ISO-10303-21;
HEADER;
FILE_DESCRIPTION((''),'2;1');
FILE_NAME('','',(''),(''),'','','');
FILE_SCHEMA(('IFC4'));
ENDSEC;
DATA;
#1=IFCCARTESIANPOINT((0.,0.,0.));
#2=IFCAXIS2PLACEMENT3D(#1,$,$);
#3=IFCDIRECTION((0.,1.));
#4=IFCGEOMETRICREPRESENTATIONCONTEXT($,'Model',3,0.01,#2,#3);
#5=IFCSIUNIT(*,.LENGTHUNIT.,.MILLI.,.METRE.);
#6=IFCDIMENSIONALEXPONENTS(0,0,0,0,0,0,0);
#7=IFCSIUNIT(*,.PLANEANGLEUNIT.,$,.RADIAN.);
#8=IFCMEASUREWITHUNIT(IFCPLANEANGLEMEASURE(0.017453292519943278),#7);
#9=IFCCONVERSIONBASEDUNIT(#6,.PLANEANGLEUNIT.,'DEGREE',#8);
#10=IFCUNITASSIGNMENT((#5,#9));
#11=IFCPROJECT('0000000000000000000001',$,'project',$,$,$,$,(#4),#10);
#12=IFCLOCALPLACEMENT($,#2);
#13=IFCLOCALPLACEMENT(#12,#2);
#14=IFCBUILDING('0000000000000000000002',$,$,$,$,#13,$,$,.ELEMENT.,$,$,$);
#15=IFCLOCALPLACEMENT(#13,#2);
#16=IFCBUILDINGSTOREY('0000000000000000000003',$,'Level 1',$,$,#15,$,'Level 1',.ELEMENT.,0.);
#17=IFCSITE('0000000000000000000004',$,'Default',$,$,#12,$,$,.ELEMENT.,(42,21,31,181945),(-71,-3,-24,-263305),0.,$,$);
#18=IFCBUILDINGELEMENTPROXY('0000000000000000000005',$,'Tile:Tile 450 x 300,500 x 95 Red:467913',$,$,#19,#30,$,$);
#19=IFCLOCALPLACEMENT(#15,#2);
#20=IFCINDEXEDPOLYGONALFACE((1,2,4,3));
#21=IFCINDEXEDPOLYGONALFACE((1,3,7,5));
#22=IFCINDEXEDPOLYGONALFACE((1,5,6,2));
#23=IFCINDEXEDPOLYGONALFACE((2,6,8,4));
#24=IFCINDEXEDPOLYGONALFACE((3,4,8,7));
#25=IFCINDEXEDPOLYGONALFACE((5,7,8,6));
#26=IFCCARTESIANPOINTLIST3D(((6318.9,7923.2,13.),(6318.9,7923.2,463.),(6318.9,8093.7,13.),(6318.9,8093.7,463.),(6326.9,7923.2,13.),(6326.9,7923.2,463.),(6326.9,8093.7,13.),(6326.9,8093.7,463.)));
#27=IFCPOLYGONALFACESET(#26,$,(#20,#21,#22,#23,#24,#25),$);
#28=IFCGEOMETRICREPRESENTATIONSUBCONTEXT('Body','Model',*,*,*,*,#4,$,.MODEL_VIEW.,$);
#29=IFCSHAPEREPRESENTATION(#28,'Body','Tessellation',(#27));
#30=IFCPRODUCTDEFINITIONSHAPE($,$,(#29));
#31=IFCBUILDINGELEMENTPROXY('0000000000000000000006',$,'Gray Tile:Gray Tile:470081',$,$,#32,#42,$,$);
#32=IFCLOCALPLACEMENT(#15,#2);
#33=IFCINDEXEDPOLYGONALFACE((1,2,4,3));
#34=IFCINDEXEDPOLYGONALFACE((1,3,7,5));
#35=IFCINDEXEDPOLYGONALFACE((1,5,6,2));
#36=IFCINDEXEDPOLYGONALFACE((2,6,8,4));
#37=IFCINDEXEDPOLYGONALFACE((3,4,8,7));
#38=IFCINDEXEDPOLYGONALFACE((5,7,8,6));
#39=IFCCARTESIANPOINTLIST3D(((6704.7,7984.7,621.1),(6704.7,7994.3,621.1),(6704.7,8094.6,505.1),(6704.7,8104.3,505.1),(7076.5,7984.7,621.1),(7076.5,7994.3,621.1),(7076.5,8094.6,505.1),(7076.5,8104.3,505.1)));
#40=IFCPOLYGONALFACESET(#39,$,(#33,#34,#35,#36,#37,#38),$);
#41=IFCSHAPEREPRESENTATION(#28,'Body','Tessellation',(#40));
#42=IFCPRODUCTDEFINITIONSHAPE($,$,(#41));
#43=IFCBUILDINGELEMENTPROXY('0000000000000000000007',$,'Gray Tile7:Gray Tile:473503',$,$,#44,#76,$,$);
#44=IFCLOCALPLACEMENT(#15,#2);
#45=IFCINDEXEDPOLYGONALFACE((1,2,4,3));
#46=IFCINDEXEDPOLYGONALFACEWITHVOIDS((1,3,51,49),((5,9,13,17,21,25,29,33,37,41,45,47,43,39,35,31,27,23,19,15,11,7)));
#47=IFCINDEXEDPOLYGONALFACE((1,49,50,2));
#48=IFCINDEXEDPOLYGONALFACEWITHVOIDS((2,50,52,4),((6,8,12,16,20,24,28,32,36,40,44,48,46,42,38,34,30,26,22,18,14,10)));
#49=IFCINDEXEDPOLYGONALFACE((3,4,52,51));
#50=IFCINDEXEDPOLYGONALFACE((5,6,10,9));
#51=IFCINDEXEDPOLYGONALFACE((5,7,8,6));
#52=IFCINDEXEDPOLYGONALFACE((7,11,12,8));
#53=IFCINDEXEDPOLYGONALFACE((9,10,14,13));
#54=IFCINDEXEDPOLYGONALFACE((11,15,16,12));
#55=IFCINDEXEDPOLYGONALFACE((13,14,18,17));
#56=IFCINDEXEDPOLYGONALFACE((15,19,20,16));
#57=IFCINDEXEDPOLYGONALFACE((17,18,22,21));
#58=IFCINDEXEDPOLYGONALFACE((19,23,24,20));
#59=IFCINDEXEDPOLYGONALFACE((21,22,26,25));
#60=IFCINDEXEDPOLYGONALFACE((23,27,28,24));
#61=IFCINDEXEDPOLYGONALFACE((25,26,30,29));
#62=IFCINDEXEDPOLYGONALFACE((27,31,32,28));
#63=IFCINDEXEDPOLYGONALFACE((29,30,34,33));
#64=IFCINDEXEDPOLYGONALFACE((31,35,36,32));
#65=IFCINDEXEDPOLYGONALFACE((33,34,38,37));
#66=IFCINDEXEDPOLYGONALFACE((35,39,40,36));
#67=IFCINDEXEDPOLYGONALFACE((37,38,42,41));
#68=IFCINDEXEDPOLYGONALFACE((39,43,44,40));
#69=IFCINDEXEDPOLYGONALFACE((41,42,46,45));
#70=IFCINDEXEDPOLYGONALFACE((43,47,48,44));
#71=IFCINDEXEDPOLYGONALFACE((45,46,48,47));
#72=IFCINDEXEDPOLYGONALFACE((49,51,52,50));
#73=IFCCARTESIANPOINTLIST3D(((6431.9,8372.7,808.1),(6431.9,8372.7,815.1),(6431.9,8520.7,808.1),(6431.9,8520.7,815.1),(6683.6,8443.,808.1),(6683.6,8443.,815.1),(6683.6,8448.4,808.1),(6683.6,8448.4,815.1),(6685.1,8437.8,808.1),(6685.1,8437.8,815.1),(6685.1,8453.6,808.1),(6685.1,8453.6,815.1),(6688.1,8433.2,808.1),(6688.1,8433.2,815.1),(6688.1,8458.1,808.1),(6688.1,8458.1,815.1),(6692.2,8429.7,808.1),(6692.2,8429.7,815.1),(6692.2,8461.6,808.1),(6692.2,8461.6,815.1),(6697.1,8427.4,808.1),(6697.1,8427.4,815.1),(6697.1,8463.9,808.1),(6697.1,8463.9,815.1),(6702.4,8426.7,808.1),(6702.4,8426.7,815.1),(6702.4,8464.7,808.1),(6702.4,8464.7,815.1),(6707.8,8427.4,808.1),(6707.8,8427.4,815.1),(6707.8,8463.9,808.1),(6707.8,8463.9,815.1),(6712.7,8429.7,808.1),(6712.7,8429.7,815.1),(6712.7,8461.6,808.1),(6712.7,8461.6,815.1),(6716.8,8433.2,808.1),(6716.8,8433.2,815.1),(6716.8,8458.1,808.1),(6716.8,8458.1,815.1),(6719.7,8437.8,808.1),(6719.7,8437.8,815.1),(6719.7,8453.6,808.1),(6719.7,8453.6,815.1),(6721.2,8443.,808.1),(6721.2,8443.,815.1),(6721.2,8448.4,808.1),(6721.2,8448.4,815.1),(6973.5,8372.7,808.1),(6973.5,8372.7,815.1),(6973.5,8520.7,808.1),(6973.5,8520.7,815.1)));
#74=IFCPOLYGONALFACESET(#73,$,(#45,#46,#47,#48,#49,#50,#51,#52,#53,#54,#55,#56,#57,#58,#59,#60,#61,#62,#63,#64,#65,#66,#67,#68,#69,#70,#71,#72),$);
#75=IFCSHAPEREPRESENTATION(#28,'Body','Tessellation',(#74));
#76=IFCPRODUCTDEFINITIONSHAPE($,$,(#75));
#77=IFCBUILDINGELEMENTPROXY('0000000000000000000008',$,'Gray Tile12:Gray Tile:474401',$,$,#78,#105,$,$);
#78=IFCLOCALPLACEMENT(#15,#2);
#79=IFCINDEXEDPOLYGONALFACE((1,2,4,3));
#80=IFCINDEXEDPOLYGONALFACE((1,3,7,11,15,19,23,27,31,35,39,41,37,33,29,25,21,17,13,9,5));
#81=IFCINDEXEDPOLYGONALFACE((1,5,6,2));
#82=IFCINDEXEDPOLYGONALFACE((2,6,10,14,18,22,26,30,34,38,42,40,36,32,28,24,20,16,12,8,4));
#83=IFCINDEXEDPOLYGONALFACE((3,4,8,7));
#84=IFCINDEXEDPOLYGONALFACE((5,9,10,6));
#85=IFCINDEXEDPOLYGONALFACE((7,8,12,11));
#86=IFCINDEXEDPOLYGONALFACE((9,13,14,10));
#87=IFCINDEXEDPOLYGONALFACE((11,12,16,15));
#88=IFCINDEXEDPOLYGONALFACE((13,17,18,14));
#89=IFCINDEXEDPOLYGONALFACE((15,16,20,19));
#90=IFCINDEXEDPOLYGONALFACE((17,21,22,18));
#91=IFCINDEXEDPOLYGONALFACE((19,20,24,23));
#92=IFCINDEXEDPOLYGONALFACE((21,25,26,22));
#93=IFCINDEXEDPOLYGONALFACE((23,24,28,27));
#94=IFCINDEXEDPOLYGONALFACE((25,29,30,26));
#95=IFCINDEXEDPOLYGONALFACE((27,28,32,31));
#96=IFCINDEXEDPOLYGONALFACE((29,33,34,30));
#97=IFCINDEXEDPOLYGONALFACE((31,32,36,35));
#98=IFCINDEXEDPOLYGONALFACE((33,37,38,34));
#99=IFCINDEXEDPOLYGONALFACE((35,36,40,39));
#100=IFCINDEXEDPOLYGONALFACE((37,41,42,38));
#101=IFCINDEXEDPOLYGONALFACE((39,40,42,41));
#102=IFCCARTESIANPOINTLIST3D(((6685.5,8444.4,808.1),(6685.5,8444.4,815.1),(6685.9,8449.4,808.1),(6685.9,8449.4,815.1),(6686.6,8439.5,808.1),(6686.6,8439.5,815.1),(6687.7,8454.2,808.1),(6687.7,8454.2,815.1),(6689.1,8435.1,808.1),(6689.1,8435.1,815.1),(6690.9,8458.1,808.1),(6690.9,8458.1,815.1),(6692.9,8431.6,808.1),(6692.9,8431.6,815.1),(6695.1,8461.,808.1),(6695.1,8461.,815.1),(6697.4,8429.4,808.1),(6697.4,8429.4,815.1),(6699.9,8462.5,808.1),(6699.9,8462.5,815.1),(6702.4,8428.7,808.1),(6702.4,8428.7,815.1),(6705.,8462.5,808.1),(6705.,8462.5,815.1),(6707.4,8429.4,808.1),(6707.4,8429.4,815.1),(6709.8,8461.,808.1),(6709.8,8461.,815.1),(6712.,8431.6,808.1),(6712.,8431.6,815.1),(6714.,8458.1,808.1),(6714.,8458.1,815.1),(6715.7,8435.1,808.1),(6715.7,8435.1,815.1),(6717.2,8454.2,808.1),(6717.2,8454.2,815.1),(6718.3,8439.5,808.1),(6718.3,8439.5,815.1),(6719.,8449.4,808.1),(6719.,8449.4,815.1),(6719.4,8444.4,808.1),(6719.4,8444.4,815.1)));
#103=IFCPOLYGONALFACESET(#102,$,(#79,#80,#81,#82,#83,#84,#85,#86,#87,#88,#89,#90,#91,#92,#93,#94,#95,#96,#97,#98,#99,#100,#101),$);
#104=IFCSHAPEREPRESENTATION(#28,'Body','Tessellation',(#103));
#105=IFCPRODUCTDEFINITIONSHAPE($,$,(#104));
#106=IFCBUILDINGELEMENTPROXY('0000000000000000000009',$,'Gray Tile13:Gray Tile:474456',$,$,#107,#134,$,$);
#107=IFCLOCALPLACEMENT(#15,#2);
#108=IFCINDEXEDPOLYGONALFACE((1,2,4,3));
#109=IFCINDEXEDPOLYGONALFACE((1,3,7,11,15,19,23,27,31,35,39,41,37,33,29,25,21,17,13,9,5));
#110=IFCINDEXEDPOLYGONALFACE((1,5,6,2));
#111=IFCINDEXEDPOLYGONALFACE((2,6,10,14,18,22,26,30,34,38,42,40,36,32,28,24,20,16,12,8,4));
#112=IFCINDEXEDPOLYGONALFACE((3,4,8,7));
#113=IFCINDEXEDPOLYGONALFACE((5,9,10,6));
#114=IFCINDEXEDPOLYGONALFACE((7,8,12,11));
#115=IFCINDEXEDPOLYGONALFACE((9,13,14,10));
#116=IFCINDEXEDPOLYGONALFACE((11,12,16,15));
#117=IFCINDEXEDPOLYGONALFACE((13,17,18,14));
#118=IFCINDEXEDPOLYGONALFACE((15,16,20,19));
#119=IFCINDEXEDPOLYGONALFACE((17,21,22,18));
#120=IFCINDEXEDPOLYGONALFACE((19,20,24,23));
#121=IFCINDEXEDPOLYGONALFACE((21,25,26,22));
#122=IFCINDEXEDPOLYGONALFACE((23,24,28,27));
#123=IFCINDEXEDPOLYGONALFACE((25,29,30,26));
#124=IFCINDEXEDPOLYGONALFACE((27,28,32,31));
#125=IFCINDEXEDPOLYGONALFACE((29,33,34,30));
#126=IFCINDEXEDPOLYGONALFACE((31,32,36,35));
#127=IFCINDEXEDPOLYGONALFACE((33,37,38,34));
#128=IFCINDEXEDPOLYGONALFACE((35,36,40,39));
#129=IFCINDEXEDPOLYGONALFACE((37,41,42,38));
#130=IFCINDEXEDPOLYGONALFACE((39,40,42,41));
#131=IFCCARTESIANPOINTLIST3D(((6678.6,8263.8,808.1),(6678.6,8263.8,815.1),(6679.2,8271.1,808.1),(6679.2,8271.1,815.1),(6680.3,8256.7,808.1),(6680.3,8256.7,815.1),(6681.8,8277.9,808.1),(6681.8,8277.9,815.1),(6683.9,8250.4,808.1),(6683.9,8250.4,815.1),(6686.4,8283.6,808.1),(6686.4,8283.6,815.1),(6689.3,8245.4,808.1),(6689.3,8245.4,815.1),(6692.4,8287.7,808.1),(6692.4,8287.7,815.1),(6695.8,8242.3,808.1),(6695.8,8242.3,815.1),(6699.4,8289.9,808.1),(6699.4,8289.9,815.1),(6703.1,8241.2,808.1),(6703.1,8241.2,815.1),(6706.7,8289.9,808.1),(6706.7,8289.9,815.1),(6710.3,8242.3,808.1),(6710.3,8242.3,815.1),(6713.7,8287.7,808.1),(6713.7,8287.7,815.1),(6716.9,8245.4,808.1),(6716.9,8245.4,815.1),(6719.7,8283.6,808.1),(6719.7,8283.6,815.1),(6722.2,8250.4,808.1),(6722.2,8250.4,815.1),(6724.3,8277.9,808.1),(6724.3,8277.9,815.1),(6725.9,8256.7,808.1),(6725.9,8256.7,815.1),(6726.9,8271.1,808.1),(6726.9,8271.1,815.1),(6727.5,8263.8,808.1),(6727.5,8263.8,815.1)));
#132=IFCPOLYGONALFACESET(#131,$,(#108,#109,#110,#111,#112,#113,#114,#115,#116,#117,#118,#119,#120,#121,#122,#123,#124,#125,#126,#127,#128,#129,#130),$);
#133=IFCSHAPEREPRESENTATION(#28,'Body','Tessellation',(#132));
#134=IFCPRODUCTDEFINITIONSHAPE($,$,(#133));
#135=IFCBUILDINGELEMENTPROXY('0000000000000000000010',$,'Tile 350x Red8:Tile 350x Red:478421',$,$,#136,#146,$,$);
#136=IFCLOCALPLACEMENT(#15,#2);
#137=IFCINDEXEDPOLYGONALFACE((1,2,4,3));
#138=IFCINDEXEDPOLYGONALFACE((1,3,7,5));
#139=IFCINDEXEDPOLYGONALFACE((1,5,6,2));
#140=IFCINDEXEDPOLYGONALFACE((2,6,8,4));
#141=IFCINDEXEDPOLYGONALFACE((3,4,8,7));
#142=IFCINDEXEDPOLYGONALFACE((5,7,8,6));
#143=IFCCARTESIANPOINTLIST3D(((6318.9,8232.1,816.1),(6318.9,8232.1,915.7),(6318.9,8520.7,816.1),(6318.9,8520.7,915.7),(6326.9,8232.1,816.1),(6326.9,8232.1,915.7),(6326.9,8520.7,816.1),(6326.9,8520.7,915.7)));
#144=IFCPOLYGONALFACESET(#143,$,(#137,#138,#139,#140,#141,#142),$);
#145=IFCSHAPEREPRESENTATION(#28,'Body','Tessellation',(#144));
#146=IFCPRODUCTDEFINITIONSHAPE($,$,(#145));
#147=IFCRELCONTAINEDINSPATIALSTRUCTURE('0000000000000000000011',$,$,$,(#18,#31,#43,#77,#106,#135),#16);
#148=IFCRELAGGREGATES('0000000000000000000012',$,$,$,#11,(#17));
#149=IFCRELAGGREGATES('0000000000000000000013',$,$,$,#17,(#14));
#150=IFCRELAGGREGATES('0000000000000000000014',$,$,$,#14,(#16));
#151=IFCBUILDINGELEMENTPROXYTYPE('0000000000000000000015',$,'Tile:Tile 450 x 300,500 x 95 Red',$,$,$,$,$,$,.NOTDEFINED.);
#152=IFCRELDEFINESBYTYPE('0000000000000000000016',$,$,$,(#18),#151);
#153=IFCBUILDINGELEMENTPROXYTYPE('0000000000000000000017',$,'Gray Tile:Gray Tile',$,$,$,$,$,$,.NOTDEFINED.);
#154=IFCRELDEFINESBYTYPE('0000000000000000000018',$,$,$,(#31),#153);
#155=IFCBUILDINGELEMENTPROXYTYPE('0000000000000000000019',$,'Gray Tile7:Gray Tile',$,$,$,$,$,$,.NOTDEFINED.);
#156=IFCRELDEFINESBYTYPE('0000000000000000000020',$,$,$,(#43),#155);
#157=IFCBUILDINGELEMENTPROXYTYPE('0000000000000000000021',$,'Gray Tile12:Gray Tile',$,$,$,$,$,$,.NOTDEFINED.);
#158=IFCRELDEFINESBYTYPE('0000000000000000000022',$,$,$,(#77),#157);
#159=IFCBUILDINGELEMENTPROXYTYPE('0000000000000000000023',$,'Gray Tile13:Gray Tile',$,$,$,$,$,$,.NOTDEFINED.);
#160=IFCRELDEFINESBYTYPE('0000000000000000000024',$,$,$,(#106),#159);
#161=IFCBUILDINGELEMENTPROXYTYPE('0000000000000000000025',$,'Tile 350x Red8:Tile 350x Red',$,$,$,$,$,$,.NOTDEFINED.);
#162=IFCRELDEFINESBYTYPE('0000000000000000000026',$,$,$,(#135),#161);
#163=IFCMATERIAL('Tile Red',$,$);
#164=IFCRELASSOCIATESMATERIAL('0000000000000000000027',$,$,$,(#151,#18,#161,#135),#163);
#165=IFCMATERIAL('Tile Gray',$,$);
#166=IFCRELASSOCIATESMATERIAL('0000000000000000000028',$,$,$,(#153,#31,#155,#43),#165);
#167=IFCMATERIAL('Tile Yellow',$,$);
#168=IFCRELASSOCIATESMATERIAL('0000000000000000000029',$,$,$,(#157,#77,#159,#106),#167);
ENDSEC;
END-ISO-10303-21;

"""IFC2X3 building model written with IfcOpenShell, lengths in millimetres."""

from ifc_helpers import new_model, entity, si_unit, converted_unit, direction, frame, frame_2d, origin, origin_2d_with_axis, place, context, subcontext, project, spatial, polyline, circle_curve, parameter, trimmed, segment, composite_curve, rectangle, circle, outline, extrude, source, transform, mapped, material, type_object, type_shapes, element, save


model = new_model("IFC2X3")

# Units and contexts
model_context = context("Model", 3, precision=0.01, world=origin(), true_north=direction((0.0, 1.0)))
body_context = subcontext(model_context, "Body", "Model", "MODEL_VIEW")
ifc_project = project(units=[si_unit("LENGTHUNIT", "METRE", prefix="MILLI"), converted_unit("PLANEANGLEUNIT", "DEGREE", entity("IfcPlaneAngleMeasure", 0.017453292519943278), si_unit("PLANEANGLEUNIT", "RADIAN"), dimensions=[0, 0, 0, 0, 0, 0, 0])], contexts=[model_context])

# Site, building, storey
site_placement = place(None, origin())
site = spatial("IfcSite", under=ifc_project, at=site_placement, Name="Default", CompositionType="ELEMENT", RefLatitude=(42, 21, 31, 181945), RefLongitude=(-71, -3, -24, -263305), RefElevation=0.0)
building_placement = place(site_placement, origin())
building = spatial("IfcBuilding", under=site, at=building_placement, CompositionType="ELEMENT")
storey_placement = place(building_placement, origin())
storey = spatial("IfcBuildingStorey", under=building, at=storey_placement, Name="Level 1", LongName="Level 1", CompositionType="ELEMENT", Elevation=0.0)

# Building element proxies
ifc_material_1 = material(Name="Tile Red")
building_element_proxy_type_1 = type_object("IfcBuildingElementProxyType", Name="Tile:Tile 450 x 300,500 x 95 Red", PredefinedType="NOTDEFINED", material=ifc_material_1)
shared_shape_1 = source(origin(), body_context, "Body", "SweptSolid", [
    extrude(rectangle(XDim=170.5, YDim=8.0, at=origin_2d_with_axis()), frame((6322.9, 8008.4, 13.0), z_axis=(0.0, 0.0, 1.0), x_axis=(0.0, 1.0, 0.0)), (0.0, 0.0, 1.0), 450.0),
])
type_shapes(building_element_proxy_type_1, [shared_shape_1])
proxy_1_placement = place(storey_placement, origin())
element("IfcBuildingElementProxy", 1, at=proxy_1_placement, inside=storey, type_object=building_element_proxy_type_1, material=ifc_material_1, Name="Tile:Tile 450 x 300,500 x 95 Red:467913", context=body_context, shape_type="MappedRepresentation", body=[
    mapped(shared_shape_1, transform((0.0, 0.0, 0.0), scale=1.0)),
])
ifc_material_2 = material(Name="Tile Gray")
building_element_proxy_type_2 = type_object("IfcBuildingElementProxyType", Name="Gray Tile:Gray Tile", PredefinedType="NOTDEFINED", material=ifc_material_2)
shared_shape_2 = source(origin(), body_context, "Body", "SweptSolid", [
    extrude(outline(polyline([(-83.2, -3.5), (76.6, -3.5), (83.2, 3.5), (-76.6, 3.5), (-83.2, -3.5)])), frame((6704.7, 8044.5, 550.1), z_axis=(1.0, 0.0, 0.0), x_axis=(0.0, -0.688092, 0.725624)), (0.0, 0.0, 1.0), 371.8),
])
type_shapes(building_element_proxy_type_2, [shared_shape_2])
proxy_2_placement = place(storey_placement, frame((0.0, 0.0, 13.0)))
element("IfcBuildingElementProxy", 2, at=proxy_2_placement, inside=storey, type_object=building_element_proxy_type_2, material=ifc_material_2, Name="Gray Tile:Gray Tile:470081", context=body_context, shape_type="MappedRepresentation", body=[
    mapped(shared_shape_2, transform((0.0, 0.0, 0.0), scale=1.0)),
])
building_element_proxy_type_3 = type_object("IfcBuildingElementProxyType", Name="Gray Tile7:Gray Tile", PredefinedType="NOTDEFINED", material=ifc_material_2)
shared_shape_3 = source(origin(), body_context, "Body", "SweptSolid", [
    extrude(outline(polyline([(-74.0, -270.8), (74.0, -270.8), (74.0, 270.8), (-74.0, 270.8), (-74.0, -270.8)]), holes=[composite_curve([segment(trimmed(circle_curve(frame_2d((-1.0, 0.3), x_axis=(-1.0, 0.0)), 19.0), [parameter(360.0)], [parameter(180.0)], True, "PARAMETER"), False, "CONTINUOUS"), segment(trimmed(circle_curve(frame_2d((-1.0, 0.3), x_axis=(-1.0, 0.0)), 19.0), [parameter(180.0)], [parameter(360.0)], True, "PARAMETER"), False, "CONTINUOUS")], self_intersect=False)]), frame((6702.7, 8446.7, 808.1), z_axis=(0.0, 0.0, 1.0), x_axis=(0.0, 1.0, 0.0)), (0.0, 0.0, 1.0), 7.0),
])
type_shapes(building_element_proxy_type_3, [shared_shape_3])
proxy_3_placement = place(storey_placement, origin())
element("IfcBuildingElementProxy", 3, at=proxy_3_placement, inside=storey, type_object=building_element_proxy_type_3, material=ifc_material_2, Name="Gray Tile7:Gray Tile:473503", context=body_context, shape_type="MappedRepresentation", body=[
    mapped(shared_shape_3, transform((0.0, 0.0, 0.0), scale=1.0)),
])
ifc_material_3 = material(Name="Tile Yellow")
building_element_proxy_type_4 = type_object("IfcBuildingElementProxyType", Name="Gray Tile12:Gray Tile", PredefinedType="NOTDEFINED", material=ifc_material_3)
shared_shape_4 = source(origin(), body_context, "Body", "SweptSolid", [
    extrude(circle(Radius=17.0, at=origin_2d_with_axis()), frame((6702.4, 8445.7, 808.1), z_axis=(0.0, 0.0, 1.0), x_axis=(0.0, -1.0, 0.0)), (0.0, 0.0, 1.0), 7.0),
])
type_shapes(building_element_proxy_type_4, [shared_shape_4])
proxy_4_placement = place(storey_placement, origin())
element("IfcBuildingElementProxy", 4, at=proxy_4_placement, inside=storey, type_object=building_element_proxy_type_4, material=ifc_material_3, Name="Gray Tile12:Gray Tile:474401", context=body_context, shape_type="MappedRepresentation", body=[
    mapped(shared_shape_4, transform((0.0, 0.0, 0.0), scale=1.0)),
])
building_element_proxy_type_5 = type_object("IfcBuildingElementProxyType", Name="Gray Tile13:Gray Tile", PredefinedType="NOTDEFINED", material=ifc_material_3)
shared_shape_5 = source(origin(), body_context, "Body", "SweptSolid", [
    extrude(circle(Radius=24.5, at=origin_2d_with_axis()), frame((6703.1, 8265.7, 808.1), z_axis=(0.0, 0.0, 1.0), x_axis=(0.0, -1.0, 0.0)), (0.0, 0.0, 1.0), 7.0),
])
type_shapes(building_element_proxy_type_5, [shared_shape_5])
proxy_5_placement = place(storey_placement, origin())
element("IfcBuildingElementProxy", 5, at=proxy_5_placement, inside=storey, type_object=building_element_proxy_type_5, material=ifc_material_3, Name="Gray Tile13:Gray Tile:474456", context=body_context, shape_type="MappedRepresentation", body=[
    mapped(shared_shape_5, transform((0.0, 0.0, 0.0), scale=1.0)),
])
building_element_proxy_type_6 = type_object("IfcBuildingElementProxyType", Name="Tile 350x Red8:Tile 350x Red", PredefinedType="NOTDEFINED", material=ifc_material_1)
shared_shape_6 = source(origin(), body_context, "Body", "SweptSolid", [
    extrude(rectangle(XDim=8.0, YDim=288.6, at=origin_2d_with_axis()), frame((6322.9, 8376.4, 816.1), z_axis=(0.0, 0.0, 1.0), x_axis=(-1.0, 0.0, 0.0)), (0.0, 0.0, 1.0), 99.6),
])
type_shapes(building_element_proxy_type_6, [shared_shape_6])
proxy_6_placement = place(storey_placement, origin())
element("IfcBuildingElementProxy", 6, at=proxy_6_placement, inside=storey, type_object=building_element_proxy_type_6, material=ifc_material_1, Name="Tile 350x Red8:Tile 350x Red:478421", context=body_context, shape_type="MappedRepresentation", body=[
    mapped(shared_shape_6, transform((0.0, 0.0, 0.0), scale=1.0)),
])

save(model, "model.ifc")
